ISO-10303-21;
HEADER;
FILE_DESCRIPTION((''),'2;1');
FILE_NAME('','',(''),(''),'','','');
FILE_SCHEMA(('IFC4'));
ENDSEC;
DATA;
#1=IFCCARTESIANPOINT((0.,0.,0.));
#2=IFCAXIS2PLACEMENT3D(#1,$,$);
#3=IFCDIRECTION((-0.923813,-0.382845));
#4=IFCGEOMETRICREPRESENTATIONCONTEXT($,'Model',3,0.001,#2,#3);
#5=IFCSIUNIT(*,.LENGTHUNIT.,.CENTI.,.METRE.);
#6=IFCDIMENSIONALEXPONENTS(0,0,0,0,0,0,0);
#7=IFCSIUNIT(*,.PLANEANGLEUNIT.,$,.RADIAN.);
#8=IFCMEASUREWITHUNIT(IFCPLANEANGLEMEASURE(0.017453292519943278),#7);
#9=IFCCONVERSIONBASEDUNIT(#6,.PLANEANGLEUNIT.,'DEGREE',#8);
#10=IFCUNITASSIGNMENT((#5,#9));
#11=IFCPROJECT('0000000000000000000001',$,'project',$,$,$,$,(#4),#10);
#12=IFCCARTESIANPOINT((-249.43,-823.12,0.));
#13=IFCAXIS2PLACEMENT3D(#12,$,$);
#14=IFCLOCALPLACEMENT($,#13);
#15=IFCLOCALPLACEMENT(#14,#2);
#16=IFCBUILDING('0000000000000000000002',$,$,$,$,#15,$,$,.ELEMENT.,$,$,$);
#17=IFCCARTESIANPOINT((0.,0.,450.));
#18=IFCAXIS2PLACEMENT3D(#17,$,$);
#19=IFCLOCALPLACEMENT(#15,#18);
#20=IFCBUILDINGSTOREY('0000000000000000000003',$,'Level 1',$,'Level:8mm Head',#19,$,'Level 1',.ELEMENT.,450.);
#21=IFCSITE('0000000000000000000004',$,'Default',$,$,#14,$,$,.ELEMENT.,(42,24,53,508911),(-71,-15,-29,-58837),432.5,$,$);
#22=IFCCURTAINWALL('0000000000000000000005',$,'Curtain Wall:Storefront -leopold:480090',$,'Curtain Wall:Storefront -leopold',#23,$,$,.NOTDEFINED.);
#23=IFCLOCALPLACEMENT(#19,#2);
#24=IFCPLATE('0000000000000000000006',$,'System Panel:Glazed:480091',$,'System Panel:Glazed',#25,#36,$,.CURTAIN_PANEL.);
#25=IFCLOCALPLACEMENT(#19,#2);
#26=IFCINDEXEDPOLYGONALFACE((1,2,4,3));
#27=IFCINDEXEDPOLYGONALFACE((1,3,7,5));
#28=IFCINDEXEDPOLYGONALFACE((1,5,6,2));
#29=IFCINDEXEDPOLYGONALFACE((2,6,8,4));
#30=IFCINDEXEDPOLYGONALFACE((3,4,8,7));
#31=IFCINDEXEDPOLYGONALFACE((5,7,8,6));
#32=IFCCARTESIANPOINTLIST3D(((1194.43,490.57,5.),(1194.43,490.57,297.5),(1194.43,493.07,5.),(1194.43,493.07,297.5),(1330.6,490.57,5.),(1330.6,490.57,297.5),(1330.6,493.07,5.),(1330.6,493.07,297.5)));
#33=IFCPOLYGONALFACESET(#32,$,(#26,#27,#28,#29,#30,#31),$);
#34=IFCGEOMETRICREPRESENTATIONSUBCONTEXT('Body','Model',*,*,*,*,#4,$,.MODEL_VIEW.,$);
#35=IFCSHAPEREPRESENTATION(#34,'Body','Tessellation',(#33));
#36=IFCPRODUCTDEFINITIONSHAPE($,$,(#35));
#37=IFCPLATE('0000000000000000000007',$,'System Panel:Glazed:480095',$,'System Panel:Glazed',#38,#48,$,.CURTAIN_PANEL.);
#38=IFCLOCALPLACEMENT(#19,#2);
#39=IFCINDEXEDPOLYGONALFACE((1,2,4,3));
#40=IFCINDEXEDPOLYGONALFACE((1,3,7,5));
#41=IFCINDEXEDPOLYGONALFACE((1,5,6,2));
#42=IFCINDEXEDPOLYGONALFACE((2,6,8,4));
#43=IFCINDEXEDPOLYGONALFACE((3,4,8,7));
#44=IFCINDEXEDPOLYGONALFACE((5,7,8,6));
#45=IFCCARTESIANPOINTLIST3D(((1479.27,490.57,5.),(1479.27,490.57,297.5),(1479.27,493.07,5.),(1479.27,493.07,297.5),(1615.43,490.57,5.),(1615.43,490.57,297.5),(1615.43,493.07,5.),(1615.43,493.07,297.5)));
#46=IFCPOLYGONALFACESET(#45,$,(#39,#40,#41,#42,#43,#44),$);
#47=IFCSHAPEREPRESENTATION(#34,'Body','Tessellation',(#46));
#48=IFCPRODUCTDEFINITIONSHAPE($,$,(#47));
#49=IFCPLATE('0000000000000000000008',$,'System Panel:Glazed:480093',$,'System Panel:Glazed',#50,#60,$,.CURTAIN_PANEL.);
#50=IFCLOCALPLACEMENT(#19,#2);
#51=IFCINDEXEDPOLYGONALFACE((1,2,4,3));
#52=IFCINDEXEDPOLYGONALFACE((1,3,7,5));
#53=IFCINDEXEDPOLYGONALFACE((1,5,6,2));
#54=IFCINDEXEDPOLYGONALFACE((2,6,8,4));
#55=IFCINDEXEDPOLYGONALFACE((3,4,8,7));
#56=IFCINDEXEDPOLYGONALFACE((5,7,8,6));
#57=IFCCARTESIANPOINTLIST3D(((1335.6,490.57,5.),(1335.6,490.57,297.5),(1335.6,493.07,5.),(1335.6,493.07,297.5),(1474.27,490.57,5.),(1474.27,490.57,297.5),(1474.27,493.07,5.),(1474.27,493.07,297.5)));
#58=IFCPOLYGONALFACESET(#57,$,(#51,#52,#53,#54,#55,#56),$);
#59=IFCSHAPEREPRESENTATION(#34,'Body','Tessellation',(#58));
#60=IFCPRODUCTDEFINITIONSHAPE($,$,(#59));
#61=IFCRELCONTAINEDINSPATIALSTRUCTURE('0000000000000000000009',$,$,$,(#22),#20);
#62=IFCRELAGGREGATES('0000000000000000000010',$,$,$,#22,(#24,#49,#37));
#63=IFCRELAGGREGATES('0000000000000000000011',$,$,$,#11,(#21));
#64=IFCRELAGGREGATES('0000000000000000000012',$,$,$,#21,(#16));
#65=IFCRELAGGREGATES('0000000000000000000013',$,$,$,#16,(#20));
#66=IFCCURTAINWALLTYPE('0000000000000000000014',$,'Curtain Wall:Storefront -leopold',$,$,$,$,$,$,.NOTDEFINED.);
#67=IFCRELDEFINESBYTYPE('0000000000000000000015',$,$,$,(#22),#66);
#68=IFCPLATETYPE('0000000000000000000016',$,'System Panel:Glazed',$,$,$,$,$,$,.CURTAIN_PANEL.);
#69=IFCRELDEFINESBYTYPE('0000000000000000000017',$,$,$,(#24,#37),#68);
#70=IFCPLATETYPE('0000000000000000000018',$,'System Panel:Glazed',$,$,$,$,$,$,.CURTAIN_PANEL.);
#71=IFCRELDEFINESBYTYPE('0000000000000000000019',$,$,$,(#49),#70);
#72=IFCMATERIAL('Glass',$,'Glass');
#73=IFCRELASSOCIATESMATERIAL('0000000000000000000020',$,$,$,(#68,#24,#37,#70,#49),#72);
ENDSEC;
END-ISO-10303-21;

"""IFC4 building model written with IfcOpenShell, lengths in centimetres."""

from ifc_helpers import new_model, entity, si_unit, converted_unit, direction, frame, origin, place, context, subcontext, project, spatial, indexed_curve, outline, extrude, source, transform, mapped, material, type_object, type_shapes, element, aggregate, save


model = new_model("IFC4")

# Units and contexts
model_context = context("Model", 3, precision=0.001, world=origin(), true_north=direction((-0.923813, -0.382845)))
body_context = subcontext(model_context, "Body", "Model", "MODEL_VIEW")
ifc_project = project(units=[si_unit("LENGTHUNIT", "METRE", prefix="CENTI"), converted_unit("PLANEANGLEUNIT", "DEGREE", entity("IfcPlaneAngleMeasure", 0.017453292519943278), si_unit("PLANEANGLEUNIT", "RADIAN"), dimensions=[0, 0, 0, 0, 0, 0, 0])], contexts=[model_context])

# Site, building, storey
site_placement = place(None, frame((-249.43, -823.12, 0.0)))
site = spatial("IfcSite", under=ifc_project, at=site_placement, Name="Default", CompositionType="ELEMENT", RefLatitude=(42, 24, 53, 508911), RefLongitude=(-71, -15, -29, -58837), RefElevation=432.5)
building_placement = place(site_placement, origin())
building = spatial("IfcBuilding", under=site, at=building_placement, CompositionType="ELEMENT")
storey_placement = place(building_placement, frame((0.0, 0.0, 450.0)))
storey = spatial("IfcBuildingStorey", under=building, at=storey_placement, Name="Level 1", ObjectType="Level:8mm Head", LongName="Level 1", CompositionType="ELEMENT", Elevation=450.0)

# Curtain wall
curtain_wall_type = type_object("IfcCurtainWallType", Name="Curtain Wall:Storefront -leopold", PredefinedType="NOTDEFINED")
curtain_wall_placement = place(storey_placement, frame((0.0, 0.0, -450.0)))
curtain_wall = element("IfcCurtainWall", 1, at=curtain_wall_placement, inside=storey, type_object=curtain_wall_type, Name="Curtain Wall:Storefront -leopold:480090", ObjectType="Curtain Wall:Storefront -leopold", PredefinedType="NOTDEFINED")

# Plates
ifc_material_1 = material(Name="Glass", Category="Glass")
plate_type_1 = type_object("IfcPlateType", Name="System Panel:Glazed", PredefinedType="CURTAIN_PANEL", material=ifc_material_1)
shared_shape_1 = source(origin(), body_context, "Body", "SweptSolid", [
    extrude(outline(indexed_curve([(-1.25, -68.08), (1.25, -68.08), (1.25, 68.08), (-1.25, 68.08), (-1.25, -68.08)], self_intersect=False)), frame((0.0, 3.7, 0.0), z_axis=(0.0, 0.0, 1.0), x_axis=(0.0, 1.0, 0.0)), (0.0, 0.0, 1.0), 292.5),
])
type_shapes(plate_type_1, [shared_shape_1])
plate_1_placement = place(curtain_wall_placement, frame((1262.52, 488.12, 455.0)))
plate_1 = element("IfcPlate", 2, at=plate_1_placement, type_object=plate_type_1, material=ifc_material_1, Name="System Panel:Glazed:480091", ObjectType="System Panel:Glazed", PredefinedType="CURTAIN_PANEL", context=body_context, shape_type="MappedRepresentation", body=[
    mapped(shared_shape_1, transform((0.0, 0.0, 0.0), scale=1.0)),
])
plate_2_placement = place(curtain_wall_placement, frame((1547.35, 488.12, 455.0)))
plate_2 = element("IfcPlate", 3, at=plate_2_placement, type_object=plate_type_1, material=ifc_material_1, Name="System Panel:Glazed:480095", ObjectType="System Panel:Glazed", PredefinedType="CURTAIN_PANEL", context=body_context, shape_type="MappedRepresentation", body=[
    mapped(shared_shape_1, transform((0.0, 0.0, 0.0), scale=1.0)),
])
plate_type_2 = type_object("IfcPlateType", Name="System Panel:Glazed", PredefinedType="CURTAIN_PANEL", material=ifc_material_1)
shared_shape_2 = source(origin(), body_context, "Body", "SweptSolid", [
    extrude(outline(indexed_curve([(-1.25, -69.33), (1.25, -69.33), (1.25, 69.33), (-1.25, 69.33), (-1.25, -69.33)], self_intersect=False)), frame((0.0, 3.7, 0.0), z_axis=(0.0, 0.0, 1.0), x_axis=(0.0, 1.0, 0.0)), (0.0, 0.0, 1.0), 292.5),
])
type_shapes(plate_type_2, [shared_shape_2])
plate_3_placement = place(curtain_wall_placement, frame((1404.93, 488.12, 455.0)))
plate_3 = element("IfcPlate", 4, at=plate_3_placement, type_object=plate_type_2, material=ifc_material_1, Name="System Panel:Glazed:480093", ObjectType="System Panel:Glazed", PredefinedType="CURTAIN_PANEL", context=body_context, shape_type="MappedRepresentation", body=[
    mapped(shared_shape_2, transform((0.0, 0.0, 0.0), scale=1.0)),
])
aggregate(curtain_wall, [plate_1, plate_3, plate_2])

save(model, "model.ifc")
